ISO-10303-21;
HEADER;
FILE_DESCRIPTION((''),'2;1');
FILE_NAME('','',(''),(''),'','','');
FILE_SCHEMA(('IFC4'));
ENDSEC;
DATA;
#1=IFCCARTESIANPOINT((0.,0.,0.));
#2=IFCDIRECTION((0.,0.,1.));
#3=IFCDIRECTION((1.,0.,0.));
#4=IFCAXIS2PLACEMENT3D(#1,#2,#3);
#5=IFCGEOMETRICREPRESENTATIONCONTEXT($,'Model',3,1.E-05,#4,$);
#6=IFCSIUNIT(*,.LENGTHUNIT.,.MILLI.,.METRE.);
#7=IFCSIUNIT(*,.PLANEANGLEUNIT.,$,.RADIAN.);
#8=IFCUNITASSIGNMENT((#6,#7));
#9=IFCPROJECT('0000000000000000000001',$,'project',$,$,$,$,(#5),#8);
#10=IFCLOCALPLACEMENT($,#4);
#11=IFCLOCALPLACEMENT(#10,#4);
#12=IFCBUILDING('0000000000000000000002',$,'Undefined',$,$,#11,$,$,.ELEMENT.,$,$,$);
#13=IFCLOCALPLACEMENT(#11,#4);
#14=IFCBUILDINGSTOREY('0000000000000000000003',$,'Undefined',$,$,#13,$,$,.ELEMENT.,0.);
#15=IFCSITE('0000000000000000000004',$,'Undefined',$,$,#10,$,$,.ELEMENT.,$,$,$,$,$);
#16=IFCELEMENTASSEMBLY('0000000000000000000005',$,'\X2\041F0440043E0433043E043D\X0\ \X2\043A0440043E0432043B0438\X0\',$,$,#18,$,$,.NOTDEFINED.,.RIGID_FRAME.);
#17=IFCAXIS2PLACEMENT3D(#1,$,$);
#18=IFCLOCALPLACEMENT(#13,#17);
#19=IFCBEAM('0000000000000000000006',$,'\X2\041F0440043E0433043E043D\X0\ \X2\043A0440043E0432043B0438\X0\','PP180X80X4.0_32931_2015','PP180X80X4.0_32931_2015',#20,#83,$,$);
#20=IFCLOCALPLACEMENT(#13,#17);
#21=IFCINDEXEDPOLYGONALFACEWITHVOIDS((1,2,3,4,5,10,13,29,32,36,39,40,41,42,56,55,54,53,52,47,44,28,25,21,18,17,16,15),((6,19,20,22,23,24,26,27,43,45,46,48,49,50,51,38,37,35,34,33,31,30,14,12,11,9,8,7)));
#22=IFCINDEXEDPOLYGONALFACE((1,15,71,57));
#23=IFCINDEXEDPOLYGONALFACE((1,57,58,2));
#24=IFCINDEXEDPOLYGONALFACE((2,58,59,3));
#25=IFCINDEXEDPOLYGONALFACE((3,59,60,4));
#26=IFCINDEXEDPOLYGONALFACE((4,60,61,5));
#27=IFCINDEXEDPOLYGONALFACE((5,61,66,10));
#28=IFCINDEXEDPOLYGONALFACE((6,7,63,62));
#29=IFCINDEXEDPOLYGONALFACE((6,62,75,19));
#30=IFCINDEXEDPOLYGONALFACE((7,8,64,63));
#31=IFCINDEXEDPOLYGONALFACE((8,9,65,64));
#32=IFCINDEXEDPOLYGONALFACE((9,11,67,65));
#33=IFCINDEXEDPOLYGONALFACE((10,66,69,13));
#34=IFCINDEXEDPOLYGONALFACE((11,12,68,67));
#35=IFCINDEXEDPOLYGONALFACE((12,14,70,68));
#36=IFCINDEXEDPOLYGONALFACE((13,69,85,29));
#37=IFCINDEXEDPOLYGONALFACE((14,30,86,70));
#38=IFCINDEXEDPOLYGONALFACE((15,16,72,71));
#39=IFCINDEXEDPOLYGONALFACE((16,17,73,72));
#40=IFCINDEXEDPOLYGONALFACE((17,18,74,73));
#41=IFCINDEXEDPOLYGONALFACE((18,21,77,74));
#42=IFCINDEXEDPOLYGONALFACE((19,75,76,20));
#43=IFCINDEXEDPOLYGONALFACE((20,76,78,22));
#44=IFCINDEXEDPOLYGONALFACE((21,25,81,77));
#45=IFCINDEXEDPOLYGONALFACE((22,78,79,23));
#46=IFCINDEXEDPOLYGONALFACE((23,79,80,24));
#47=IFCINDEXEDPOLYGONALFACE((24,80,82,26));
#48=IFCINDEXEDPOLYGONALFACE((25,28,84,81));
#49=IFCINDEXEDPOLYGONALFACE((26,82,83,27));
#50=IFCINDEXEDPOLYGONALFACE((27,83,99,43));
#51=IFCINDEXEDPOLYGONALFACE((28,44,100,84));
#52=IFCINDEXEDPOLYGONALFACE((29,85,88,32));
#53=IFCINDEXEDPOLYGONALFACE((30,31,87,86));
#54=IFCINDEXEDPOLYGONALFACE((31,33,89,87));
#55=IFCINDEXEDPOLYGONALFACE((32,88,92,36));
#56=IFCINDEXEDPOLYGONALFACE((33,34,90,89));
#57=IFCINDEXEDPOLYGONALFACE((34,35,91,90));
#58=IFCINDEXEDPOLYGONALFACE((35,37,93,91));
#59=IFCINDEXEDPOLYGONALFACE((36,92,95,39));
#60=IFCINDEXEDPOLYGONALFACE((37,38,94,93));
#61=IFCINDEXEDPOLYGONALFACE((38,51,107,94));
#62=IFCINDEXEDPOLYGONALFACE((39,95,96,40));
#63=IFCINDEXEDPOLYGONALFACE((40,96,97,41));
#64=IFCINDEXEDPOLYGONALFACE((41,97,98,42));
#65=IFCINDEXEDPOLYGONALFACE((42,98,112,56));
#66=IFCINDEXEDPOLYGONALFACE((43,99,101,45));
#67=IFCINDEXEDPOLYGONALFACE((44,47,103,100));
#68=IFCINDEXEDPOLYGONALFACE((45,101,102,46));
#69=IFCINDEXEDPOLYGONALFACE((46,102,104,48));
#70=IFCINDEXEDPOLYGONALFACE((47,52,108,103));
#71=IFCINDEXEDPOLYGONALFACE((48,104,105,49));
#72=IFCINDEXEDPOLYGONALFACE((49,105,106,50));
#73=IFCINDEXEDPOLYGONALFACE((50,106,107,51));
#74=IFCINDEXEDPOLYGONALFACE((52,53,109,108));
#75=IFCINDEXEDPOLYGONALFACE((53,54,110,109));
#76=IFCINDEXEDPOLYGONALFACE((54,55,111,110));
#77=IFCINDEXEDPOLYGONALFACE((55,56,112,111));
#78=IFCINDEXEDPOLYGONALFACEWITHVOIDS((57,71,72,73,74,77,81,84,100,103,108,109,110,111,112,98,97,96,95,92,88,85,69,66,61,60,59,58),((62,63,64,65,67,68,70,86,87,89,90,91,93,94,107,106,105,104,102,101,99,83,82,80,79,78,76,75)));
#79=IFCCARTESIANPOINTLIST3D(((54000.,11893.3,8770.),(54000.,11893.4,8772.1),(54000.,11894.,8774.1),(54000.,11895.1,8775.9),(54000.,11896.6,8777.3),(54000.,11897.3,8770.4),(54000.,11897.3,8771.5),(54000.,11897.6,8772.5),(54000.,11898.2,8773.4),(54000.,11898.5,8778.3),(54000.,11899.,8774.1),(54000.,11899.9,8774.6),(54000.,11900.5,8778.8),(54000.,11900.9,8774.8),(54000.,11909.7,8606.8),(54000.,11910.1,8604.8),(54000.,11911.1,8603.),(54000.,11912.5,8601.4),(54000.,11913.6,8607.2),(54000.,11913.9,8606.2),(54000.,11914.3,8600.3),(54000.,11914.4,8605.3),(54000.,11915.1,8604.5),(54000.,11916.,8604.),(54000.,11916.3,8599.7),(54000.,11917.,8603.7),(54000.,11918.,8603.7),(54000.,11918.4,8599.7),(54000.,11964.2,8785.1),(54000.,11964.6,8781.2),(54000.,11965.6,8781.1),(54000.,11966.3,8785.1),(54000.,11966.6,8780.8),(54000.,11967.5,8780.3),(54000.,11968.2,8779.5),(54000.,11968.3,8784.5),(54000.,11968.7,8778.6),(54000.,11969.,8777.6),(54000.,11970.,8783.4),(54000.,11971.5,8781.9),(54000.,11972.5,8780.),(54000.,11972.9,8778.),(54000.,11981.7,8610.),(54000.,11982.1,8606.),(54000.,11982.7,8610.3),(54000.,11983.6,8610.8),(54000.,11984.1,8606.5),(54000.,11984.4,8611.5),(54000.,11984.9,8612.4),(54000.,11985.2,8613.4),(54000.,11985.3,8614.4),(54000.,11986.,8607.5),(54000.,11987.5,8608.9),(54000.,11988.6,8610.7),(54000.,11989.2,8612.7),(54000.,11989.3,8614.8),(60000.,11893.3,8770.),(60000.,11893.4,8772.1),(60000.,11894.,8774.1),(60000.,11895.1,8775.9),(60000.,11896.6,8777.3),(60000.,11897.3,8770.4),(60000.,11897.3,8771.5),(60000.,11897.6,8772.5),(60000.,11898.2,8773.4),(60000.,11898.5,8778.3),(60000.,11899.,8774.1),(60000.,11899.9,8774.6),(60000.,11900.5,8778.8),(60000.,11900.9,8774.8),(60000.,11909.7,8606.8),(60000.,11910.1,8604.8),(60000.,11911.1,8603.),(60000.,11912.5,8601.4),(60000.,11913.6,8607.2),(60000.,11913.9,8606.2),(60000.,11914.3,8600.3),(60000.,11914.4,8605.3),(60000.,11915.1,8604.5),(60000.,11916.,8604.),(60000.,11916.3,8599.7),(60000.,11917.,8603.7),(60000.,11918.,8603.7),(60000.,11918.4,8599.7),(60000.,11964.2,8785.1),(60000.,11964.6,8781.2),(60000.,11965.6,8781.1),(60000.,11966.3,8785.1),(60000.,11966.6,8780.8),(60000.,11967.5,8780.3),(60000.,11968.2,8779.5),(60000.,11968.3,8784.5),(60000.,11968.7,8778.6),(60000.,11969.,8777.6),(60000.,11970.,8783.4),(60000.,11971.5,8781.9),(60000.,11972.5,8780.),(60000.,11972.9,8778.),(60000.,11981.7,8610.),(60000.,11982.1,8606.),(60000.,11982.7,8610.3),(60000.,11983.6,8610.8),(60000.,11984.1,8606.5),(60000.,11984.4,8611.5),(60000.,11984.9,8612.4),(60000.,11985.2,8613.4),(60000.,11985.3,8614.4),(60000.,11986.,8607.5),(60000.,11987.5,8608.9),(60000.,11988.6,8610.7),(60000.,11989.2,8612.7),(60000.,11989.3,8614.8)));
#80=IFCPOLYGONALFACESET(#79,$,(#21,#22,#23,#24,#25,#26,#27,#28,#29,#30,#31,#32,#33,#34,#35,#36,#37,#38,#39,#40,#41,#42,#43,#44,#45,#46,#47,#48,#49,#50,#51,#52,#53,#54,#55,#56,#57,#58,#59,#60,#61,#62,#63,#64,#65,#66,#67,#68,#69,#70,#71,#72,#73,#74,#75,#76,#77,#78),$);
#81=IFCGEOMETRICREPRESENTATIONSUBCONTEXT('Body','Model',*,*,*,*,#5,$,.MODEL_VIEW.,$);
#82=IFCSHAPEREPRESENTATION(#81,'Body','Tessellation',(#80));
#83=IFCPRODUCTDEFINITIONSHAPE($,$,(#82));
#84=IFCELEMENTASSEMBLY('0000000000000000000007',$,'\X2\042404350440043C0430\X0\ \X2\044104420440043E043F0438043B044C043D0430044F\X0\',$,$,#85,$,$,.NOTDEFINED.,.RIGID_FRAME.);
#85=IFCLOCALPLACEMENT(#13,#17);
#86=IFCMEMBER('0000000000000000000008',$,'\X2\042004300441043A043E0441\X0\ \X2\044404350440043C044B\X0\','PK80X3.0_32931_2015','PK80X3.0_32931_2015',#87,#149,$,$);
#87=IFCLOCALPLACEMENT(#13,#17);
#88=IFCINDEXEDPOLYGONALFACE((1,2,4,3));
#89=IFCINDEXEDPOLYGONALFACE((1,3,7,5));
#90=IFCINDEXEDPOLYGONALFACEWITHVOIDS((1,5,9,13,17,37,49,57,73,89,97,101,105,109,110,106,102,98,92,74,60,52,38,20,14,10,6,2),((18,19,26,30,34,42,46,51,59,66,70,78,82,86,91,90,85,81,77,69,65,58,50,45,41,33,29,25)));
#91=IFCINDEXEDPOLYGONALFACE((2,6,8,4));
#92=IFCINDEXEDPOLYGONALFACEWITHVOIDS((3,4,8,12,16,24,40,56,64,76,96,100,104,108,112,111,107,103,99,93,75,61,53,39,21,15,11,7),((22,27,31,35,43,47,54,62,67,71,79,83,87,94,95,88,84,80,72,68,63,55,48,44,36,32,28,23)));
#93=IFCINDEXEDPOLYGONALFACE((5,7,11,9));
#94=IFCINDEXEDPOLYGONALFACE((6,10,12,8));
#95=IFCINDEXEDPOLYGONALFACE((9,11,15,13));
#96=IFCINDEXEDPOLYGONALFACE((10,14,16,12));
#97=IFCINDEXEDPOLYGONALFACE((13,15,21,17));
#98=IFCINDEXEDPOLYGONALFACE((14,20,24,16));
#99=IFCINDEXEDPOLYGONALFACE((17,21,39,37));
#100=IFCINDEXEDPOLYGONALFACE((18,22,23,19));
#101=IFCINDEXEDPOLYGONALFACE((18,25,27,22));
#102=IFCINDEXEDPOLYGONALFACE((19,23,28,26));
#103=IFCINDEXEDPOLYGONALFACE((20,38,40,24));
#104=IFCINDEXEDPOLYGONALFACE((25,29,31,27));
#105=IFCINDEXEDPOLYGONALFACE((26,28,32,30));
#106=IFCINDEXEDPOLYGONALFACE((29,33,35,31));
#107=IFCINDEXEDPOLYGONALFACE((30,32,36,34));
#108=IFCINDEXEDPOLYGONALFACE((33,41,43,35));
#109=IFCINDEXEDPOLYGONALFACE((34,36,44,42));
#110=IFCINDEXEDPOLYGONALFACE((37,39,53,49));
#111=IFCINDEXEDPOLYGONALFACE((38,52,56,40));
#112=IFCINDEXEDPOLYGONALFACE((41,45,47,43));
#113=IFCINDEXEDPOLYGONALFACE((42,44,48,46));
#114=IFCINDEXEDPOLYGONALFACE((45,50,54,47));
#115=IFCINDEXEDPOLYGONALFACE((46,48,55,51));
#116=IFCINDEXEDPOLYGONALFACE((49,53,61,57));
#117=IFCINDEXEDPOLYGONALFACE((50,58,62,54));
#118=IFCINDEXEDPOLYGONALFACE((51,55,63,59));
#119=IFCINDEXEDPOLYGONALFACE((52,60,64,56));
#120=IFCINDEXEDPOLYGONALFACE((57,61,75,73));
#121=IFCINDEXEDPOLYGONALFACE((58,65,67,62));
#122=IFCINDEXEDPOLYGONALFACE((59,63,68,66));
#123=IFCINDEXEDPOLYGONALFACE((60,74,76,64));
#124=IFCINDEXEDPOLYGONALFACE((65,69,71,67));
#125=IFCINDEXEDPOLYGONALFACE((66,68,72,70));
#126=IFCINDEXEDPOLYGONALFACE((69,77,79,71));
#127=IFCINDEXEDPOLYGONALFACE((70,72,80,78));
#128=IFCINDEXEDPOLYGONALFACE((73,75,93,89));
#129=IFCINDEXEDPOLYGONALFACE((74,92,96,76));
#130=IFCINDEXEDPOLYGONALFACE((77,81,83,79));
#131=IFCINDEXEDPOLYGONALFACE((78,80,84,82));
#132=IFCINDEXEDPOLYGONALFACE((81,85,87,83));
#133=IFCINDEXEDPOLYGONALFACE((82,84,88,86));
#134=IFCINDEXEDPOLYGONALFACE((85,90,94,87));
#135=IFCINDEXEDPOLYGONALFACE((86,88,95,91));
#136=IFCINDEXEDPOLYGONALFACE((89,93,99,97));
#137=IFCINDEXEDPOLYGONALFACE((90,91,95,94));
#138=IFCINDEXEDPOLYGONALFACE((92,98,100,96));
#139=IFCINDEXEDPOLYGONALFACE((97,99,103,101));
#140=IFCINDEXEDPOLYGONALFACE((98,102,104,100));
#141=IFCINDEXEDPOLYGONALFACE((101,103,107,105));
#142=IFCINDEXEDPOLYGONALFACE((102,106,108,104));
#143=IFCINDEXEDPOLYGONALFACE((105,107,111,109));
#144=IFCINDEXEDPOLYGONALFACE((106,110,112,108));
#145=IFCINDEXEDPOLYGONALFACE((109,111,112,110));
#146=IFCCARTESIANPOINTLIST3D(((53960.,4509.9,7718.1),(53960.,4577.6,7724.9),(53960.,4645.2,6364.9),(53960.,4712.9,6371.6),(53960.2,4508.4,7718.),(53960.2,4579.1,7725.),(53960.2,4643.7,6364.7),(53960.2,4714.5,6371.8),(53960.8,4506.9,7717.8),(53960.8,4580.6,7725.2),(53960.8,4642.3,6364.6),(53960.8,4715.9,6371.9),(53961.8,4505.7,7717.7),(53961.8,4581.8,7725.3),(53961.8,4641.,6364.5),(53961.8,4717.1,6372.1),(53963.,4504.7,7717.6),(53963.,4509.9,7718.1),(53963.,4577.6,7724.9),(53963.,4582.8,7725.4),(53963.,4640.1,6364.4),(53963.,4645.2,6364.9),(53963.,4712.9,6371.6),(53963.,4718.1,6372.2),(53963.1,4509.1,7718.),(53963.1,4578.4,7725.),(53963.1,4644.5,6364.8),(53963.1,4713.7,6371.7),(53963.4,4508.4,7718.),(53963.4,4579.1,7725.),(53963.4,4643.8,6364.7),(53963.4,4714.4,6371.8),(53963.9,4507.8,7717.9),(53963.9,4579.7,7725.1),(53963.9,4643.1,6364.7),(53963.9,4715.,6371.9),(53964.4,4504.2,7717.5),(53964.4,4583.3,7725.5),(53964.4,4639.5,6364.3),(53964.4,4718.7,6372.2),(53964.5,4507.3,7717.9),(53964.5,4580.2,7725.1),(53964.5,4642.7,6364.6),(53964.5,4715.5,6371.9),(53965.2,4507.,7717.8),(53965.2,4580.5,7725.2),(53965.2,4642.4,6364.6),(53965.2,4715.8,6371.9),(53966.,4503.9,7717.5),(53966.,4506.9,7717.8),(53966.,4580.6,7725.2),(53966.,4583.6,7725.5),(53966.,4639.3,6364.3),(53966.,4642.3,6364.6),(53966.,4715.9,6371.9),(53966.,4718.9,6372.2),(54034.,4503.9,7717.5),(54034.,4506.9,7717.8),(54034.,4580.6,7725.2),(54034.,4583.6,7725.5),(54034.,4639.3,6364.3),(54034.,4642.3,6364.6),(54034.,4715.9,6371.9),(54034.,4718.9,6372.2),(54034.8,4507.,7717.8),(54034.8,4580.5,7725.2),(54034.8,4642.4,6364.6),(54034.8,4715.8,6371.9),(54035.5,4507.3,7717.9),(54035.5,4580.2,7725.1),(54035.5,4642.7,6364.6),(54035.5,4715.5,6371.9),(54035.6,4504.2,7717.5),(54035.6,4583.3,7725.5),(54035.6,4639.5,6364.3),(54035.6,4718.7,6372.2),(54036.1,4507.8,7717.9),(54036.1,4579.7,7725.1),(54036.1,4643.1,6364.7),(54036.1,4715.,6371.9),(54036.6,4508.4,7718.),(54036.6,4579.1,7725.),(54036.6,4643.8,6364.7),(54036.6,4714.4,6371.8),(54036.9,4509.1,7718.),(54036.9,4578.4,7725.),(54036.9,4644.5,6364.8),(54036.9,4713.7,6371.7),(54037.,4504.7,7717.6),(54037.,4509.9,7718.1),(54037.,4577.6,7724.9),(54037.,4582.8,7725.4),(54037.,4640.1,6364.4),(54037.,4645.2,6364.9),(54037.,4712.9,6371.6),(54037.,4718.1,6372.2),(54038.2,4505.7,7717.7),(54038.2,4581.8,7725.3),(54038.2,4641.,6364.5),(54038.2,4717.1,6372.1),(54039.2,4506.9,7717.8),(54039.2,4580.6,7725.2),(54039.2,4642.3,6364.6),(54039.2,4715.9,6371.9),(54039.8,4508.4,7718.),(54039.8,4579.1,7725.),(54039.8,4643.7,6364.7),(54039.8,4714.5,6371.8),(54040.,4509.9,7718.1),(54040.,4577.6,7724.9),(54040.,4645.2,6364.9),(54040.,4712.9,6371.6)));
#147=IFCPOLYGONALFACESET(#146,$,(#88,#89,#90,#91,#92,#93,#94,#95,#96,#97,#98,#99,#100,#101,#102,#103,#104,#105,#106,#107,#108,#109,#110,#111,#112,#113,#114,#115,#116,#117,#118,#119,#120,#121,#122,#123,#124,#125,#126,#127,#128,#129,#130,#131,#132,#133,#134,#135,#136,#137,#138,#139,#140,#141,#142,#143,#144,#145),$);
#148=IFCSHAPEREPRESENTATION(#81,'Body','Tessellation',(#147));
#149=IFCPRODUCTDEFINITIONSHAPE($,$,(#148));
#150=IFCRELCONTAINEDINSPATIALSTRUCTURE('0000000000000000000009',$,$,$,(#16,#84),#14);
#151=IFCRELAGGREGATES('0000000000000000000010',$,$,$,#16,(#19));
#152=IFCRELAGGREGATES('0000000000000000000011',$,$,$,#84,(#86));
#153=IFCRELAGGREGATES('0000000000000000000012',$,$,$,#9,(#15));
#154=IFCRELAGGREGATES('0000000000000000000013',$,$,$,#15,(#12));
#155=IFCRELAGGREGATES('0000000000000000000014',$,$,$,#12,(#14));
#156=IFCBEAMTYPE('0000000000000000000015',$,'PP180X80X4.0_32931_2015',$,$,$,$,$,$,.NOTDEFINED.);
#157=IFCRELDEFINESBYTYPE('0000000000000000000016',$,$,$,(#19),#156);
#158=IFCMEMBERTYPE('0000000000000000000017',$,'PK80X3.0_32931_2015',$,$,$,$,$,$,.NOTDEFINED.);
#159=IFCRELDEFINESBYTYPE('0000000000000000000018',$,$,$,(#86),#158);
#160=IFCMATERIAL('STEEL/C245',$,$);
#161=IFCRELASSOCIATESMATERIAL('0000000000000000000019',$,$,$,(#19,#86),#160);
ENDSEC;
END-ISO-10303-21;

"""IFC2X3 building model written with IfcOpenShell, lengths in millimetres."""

from ifc_helpers import new_model, si_unit, frame, origin_with_axes, origin_2d_with_axis, place, context, subcontext, project, spatial, hollow_rectangle, extrude, material, type_object, element, aggregate, save


model = new_model("IFC2X3")

# Units and contexts
model_context = context("Model", 3, precision=1e-05, world=origin_with_axes())
body_context = subcontext(model_context, "Body", "Model", "MODEL_VIEW")
ifc_project = project(units=[si_unit("LENGTHUNIT", "METRE", prefix="MILLI"), si_unit("PLANEANGLEUNIT", "RADIAN")], contexts=[model_context])

# Site, building, storey
site_placement = place(None, origin_with_axes())
site = spatial("IfcSite", under=ifc_project, at=site_placement, Name="Undefined", CompositionType="ELEMENT")
building_placement = place(site_placement, origin_with_axes())
building = spatial("IfcBuilding", under=site, at=building_placement, Name="Undefined", CompositionType="ELEMENT")
storey_placement = place(building_placement, origin_with_axes())
storey = spatial("IfcBuildingStorey", under=building, at=storey_placement, Name="Undefined", CompositionType="ELEMENT", Elevation=0.0)

# Shared definitions
ifc_material_1 = material(Name="STEEL/C245")

# Element assembly, beam
assembly_1_placement = place(storey_placement, origin_with_axes())
assembly_1 = element("IfcElementAssembly", 1, at=assembly_1_placement, inside=storey, Name="Прогон кровли", AssemblyPlace="NOTDEFINED", PredefinedType="RIGID_FRAME")
beam_type_1 = type_object("IfcBeamType", Name="PP180X80X4.0_32931_2015", PredefinedType="NOTDEFINED")
beam_1_placement = place(assembly_1_placement, frame((54000.0, 11941.3, 8692.4), z_axis=(0.0, -0.099504, 0.995037), x_axis=(1.0, 0.0, 0.0)))
beam_1 = element("IfcBeam", 2, at=beam_1_placement, type_object=beam_type_1, material=ifc_material_1, Name="Прогон кровли", Description="PP180X80X4.0_32931_2015", ObjectType="PP180X80X4.0_32931_2015", context=body_context, shape_type="SweptSolid", body=[
    extrude(hollow_rectangle(XDim=80.0, YDim=180.0, WallThickness=4.0, InnerFilletRadius=4.0, OuterFilletRadius=8.0, at=origin_2d_with_axis()), frame((6000.0, 0.0, 0.0), z_axis=(-1.0, 0.0, 0.0), x_axis=(0.0, -1.0, 0.0)), (0.0, 0.0, 1.0), 6000.0),
])
aggregate(assembly_1, [beam_1])

# Element assembly, member
assembly_2_placement = place(storey_placement, origin_with_axes())
assembly_2 = element("IfcElementAssembly", 3, at=assembly_2_placement, inside=storey, Name="Ферма стропильная", AssemblyPlace="NOTDEFINED", PredefinedType="RIGID_FRAME")
member_type_1 = type_object("IfcMemberType", Name="PK80X3.0_32931_2015", PredefinedType="NOTDEFINED")
member_1_placement = place(assembly_2_placement, frame((54000.0, 4543.8, 7721.5), z_axis=(0.0, 0.995037, 0.099504), x_axis=(0.0, 0.099504, -0.995037)))
member_1 = element("IfcMember", 4, at=member_1_placement, type_object=member_type_1, material=ifc_material_1, Name="Раскос фермы", Description="PK80X3.0_32931_2015", ObjectType="PK80X3.0_32931_2015", context=body_context, shape_type="SweptSolid", body=[
    extrude(hollow_rectangle(XDim=80.0, YDim=80.0, WallThickness=3.0, InnerFilletRadius=3.0, OuterFilletRadius=6.0, at=origin_2d_with_axis()), frame((1360.0, 0.0, 0.0), z_axis=(-1.0, 0.0, 0.0), x_axis=(0.0, -1.0, 0.0)), (0.0, 0.0, 1.0), 1360.0),
])
aggregate(assembly_2, [member_1])

save(model, "model.ifc")
